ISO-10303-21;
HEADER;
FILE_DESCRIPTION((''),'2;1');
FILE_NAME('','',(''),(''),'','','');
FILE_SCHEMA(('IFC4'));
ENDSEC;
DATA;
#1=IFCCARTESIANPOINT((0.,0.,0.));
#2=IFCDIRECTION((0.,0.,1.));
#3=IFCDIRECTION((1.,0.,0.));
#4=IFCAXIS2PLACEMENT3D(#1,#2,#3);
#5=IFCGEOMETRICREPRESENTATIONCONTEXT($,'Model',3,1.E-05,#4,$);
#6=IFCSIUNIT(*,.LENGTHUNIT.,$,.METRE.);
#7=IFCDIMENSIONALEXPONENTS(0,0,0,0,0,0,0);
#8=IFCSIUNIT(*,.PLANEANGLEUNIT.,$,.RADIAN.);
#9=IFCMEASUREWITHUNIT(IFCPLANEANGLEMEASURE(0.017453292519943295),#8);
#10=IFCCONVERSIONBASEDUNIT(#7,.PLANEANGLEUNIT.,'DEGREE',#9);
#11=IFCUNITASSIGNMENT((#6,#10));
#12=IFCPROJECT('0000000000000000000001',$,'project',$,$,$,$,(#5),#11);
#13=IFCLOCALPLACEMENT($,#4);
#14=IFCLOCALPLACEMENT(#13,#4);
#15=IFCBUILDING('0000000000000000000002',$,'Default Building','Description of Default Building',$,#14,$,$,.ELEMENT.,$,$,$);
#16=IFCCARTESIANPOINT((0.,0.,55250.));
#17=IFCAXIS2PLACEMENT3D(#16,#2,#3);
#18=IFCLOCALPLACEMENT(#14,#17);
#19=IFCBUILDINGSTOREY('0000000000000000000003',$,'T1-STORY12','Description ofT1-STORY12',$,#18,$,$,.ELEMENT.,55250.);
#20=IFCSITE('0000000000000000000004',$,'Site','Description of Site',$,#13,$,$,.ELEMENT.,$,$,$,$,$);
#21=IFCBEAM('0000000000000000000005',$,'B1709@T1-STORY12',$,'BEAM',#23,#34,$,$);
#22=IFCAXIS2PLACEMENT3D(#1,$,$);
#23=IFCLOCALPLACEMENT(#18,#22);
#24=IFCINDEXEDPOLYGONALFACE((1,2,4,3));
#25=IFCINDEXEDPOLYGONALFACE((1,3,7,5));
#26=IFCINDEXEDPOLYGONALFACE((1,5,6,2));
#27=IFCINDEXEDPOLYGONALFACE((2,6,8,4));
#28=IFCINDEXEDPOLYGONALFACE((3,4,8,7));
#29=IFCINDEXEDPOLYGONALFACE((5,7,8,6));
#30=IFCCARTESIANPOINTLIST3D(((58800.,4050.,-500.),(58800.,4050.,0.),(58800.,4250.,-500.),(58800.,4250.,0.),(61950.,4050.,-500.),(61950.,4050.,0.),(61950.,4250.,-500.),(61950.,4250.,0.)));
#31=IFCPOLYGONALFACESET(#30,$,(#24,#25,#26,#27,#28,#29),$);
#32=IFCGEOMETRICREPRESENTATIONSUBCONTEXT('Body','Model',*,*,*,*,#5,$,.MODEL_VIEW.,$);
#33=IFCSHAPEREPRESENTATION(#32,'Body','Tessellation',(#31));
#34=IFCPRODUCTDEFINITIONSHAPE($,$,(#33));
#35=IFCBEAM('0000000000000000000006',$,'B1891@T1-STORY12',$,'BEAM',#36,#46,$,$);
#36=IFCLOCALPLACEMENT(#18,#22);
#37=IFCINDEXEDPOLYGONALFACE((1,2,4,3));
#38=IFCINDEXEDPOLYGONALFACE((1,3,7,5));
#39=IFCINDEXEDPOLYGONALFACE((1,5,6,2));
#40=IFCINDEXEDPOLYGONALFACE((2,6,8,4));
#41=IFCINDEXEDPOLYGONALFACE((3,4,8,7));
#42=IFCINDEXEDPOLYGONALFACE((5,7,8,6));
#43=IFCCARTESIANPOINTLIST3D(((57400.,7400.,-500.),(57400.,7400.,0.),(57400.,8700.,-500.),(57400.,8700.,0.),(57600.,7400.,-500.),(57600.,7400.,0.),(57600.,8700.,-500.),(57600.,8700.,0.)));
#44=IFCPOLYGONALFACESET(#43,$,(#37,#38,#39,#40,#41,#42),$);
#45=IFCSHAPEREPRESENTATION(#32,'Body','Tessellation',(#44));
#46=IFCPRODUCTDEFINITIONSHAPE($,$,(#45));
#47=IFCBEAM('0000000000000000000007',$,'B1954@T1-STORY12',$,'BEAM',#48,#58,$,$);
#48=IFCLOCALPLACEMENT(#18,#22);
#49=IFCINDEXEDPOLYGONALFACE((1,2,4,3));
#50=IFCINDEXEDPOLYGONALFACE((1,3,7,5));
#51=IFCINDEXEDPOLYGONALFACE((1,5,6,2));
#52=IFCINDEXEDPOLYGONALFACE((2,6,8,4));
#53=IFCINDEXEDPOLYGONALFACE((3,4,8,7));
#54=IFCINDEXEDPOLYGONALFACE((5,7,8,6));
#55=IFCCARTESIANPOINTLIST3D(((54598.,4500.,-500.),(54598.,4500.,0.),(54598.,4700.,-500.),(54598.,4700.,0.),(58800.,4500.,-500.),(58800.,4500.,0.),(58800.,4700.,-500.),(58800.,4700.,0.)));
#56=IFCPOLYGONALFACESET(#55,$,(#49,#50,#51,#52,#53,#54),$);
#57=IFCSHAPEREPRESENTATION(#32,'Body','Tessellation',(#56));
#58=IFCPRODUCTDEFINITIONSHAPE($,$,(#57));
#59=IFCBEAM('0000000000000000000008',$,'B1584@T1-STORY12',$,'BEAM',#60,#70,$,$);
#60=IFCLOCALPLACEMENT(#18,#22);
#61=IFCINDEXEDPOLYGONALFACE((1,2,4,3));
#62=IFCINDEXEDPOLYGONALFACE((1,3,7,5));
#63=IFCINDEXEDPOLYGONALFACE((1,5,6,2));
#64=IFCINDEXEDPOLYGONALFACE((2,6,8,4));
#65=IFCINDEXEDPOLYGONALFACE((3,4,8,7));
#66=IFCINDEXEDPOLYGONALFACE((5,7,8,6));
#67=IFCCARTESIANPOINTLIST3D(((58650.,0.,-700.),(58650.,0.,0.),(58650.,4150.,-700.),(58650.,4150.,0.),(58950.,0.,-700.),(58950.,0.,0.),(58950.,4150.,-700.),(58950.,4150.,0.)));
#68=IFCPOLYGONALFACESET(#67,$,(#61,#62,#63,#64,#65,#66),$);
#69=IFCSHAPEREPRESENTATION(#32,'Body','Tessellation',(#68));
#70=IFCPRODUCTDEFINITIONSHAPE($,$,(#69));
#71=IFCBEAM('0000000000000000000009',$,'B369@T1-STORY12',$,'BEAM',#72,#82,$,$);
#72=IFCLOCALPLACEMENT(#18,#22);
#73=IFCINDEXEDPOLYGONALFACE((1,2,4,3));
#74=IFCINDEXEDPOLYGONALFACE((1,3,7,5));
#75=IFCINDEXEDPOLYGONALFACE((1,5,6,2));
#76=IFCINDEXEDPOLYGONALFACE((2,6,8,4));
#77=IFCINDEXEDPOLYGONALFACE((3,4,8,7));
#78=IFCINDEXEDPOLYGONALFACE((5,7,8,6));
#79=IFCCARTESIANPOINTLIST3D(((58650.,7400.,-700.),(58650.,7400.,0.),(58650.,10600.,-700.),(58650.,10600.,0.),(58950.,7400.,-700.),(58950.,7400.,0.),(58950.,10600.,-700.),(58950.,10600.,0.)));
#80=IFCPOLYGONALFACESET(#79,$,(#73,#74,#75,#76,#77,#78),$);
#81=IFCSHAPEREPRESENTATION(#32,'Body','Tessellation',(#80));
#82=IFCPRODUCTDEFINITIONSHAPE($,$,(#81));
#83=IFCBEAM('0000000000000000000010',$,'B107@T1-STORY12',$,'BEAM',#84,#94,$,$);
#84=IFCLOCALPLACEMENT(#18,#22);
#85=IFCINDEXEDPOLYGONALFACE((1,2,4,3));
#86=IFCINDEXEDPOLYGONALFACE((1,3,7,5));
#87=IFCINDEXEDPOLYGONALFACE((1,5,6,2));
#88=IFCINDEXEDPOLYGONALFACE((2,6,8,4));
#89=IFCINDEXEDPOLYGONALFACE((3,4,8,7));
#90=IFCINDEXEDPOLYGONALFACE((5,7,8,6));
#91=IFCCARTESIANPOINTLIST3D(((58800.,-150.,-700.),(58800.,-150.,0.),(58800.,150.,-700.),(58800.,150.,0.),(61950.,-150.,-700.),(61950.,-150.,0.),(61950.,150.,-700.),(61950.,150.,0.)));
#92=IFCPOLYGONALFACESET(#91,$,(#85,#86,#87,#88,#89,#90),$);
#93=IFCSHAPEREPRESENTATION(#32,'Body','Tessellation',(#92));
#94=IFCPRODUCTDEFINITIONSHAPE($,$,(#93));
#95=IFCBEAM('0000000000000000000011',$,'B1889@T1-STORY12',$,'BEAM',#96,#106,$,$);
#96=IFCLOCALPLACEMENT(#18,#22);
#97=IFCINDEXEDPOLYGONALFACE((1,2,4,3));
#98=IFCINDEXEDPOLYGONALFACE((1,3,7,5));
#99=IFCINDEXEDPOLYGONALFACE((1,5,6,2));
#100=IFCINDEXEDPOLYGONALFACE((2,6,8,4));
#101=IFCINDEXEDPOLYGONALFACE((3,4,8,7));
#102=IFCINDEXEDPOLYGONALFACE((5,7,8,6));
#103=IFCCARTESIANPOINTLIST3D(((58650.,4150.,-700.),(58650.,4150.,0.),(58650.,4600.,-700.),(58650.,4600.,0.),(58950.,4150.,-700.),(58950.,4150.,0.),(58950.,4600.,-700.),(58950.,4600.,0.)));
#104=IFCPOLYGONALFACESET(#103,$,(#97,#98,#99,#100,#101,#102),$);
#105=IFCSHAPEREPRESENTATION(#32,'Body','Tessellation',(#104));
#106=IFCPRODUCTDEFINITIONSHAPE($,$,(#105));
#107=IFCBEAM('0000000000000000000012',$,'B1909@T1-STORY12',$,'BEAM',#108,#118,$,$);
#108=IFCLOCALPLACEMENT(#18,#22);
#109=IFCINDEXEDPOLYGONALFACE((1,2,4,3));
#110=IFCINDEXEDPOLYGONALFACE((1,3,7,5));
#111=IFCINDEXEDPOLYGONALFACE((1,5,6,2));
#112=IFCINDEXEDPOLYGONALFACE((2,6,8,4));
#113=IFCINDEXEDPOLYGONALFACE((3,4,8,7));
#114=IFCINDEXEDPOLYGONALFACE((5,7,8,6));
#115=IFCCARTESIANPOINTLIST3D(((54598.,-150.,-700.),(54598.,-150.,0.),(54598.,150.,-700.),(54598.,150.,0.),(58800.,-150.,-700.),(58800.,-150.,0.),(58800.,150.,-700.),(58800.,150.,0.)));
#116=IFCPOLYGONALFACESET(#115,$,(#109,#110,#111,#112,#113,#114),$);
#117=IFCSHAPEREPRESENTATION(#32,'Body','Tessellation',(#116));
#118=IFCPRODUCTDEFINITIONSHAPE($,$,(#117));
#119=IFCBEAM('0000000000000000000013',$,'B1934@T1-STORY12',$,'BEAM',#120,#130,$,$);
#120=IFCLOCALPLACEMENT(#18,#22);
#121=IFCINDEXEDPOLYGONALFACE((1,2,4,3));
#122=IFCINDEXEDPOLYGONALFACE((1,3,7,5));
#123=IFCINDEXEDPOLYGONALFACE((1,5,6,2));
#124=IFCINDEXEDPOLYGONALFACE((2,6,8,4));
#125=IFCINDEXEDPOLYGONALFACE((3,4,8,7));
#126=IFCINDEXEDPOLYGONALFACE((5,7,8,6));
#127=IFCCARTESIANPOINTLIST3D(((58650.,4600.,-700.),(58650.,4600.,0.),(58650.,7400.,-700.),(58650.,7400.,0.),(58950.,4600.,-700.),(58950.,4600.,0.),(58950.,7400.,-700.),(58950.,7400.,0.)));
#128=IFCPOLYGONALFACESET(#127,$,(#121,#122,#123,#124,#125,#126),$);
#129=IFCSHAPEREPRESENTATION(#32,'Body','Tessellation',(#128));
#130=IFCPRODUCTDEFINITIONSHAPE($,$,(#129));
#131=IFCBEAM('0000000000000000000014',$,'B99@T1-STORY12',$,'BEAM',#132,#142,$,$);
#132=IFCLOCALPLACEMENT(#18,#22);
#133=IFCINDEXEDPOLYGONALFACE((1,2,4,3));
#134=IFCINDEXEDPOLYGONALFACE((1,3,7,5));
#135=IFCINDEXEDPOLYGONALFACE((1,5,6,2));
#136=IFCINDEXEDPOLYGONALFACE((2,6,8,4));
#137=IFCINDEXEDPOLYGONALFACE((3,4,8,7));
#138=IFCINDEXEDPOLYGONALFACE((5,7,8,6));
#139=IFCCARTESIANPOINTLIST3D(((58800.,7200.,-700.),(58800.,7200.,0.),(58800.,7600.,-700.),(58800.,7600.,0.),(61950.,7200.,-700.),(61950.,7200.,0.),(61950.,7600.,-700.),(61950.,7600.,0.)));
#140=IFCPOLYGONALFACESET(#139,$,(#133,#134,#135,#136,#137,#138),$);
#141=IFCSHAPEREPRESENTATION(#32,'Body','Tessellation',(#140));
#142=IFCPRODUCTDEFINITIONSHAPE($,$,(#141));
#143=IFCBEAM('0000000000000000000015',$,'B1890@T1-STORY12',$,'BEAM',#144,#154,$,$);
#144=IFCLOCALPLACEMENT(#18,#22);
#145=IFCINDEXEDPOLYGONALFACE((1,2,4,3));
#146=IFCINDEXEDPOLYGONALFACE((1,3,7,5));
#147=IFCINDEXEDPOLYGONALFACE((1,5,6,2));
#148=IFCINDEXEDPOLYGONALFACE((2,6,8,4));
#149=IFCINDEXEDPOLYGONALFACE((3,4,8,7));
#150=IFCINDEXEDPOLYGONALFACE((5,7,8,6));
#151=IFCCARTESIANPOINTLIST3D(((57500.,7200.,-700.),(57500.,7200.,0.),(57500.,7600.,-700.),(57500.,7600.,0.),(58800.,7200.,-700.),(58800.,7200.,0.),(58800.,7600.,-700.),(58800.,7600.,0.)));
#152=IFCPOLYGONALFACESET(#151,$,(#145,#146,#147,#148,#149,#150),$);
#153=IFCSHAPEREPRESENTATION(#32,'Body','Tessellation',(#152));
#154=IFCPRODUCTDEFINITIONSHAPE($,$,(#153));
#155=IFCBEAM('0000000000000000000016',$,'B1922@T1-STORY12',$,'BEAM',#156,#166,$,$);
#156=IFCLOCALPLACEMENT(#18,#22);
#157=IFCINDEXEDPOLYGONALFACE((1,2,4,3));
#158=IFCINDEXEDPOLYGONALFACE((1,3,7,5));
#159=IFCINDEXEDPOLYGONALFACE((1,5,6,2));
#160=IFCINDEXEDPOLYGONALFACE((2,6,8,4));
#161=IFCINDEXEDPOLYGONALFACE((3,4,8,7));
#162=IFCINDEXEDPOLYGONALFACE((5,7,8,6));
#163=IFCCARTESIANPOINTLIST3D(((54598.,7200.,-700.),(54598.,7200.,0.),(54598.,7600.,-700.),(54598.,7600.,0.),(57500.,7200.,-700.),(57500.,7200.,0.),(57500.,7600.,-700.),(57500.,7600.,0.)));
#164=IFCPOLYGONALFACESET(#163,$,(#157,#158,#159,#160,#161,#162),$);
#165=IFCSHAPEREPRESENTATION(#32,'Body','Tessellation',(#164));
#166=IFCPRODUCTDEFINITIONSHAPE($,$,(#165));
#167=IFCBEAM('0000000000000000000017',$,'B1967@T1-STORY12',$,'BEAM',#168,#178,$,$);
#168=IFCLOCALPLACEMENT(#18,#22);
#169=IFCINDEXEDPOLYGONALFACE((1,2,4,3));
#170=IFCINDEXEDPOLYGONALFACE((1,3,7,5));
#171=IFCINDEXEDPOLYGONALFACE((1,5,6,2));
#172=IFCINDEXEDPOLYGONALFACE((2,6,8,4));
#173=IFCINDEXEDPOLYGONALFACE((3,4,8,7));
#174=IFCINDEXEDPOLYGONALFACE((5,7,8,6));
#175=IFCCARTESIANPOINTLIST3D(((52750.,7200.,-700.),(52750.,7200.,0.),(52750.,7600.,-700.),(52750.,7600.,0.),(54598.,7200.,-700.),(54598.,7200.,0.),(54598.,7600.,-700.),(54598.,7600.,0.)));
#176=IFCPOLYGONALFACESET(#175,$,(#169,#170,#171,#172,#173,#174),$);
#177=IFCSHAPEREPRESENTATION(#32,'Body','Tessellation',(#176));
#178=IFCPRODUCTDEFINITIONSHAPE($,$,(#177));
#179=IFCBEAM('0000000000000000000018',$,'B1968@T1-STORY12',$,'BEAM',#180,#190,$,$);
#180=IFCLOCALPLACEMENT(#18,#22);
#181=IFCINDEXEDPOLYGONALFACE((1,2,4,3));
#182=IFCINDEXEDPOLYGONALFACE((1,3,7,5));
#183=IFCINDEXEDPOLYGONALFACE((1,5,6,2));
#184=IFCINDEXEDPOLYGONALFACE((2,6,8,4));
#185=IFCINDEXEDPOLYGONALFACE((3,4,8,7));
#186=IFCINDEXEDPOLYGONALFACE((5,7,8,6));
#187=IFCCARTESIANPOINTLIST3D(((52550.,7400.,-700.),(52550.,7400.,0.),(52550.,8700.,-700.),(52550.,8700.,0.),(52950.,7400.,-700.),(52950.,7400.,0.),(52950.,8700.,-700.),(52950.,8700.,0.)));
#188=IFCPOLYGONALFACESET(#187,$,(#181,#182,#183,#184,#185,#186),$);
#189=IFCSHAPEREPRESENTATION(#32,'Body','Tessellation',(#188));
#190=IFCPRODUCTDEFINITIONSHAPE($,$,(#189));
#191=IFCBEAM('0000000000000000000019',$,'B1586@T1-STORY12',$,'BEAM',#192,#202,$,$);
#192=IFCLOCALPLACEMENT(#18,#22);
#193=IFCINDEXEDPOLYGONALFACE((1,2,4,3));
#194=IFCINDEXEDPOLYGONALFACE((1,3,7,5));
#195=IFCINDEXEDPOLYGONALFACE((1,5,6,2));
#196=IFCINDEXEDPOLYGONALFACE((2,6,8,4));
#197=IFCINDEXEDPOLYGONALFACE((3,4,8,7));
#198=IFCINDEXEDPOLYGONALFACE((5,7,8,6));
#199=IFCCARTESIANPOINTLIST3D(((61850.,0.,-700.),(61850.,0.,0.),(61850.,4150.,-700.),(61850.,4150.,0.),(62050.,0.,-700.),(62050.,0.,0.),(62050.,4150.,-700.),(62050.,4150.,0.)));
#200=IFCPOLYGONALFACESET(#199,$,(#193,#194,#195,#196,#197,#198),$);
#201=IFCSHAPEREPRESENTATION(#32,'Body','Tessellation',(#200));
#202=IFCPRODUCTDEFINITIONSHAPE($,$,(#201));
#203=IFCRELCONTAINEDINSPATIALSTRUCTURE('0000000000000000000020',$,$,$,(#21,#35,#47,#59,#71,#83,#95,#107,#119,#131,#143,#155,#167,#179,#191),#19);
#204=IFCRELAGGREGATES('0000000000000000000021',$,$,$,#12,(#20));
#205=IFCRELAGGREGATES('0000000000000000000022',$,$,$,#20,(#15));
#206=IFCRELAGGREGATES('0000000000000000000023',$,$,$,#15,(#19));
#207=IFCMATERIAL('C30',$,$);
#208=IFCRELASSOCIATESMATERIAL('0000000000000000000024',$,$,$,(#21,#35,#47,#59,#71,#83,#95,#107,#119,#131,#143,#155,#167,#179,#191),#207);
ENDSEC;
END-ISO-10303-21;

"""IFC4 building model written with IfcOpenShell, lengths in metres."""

from ifc_helpers import new_model, entity, si_unit, converted_unit, frame, origin_with_axes, place, context, subcontext, project, spatial, rectangle, extrude, material, element, save


model = new_model("IFC4")

# Units and contexts
model_context = context("Model", 3, precision=1e-05, world=origin_with_axes())
body_context = subcontext(model_context, "Body", "Model", "MODEL_VIEW")
ifc_project = project(units=[si_unit("LENGTHUNIT", "METRE"), converted_unit("PLANEANGLEUNIT", "DEGREE", entity("IfcPlaneAngleMeasure", 0.017453292519943295), si_unit("PLANEANGLEUNIT", "RADIAN"), dimensions=[0, 0, 0, 0, 0, 0, 0])], contexts=[model_context])

# Site, building, storey
site_placement = place(None, origin_with_axes())
site = spatial("IfcSite", under=ifc_project, at=site_placement, Name="Site", Description="Description of Site", CompositionType="ELEMENT")
building_placement = place(site_placement, origin_with_axes())
building = spatial("IfcBuilding", under=site, at=building_placement, Name="Default Building", Description="Description of Default Building", CompositionType="ELEMENT")
storey_placement = place(building_placement, frame((0.0, 0.0, 55250.0), z_axis=(0.0, 0.0, 1.0), x_axis=(1.0, 0.0, 0.0)))
storey = spatial("IfcBuildingStorey", under=building, at=storey_placement, Name="T1-STORY12", Description="Description ofT1-STORY12", CompositionType="ELEMENT", Elevation=55250.0)

# Beams
ifc_material_1 = material(Name="C30")
beam_1_placement = place(storey_placement, frame((58800.0, 4150.0, -250.0), z_axis=(1.0, 0.0, 0.0), x_axis=(0.0, 1.0, 0.0)))
element("IfcBeam", 1, at=beam_1_placement, inside=storey, material=ifc_material_1, Name="B1709@T1-STORY12", ObjectType="BEAM", context=body_context, shape_type="SweptSolid", body=[
    extrude(rectangle(XDim=200.0, YDim=500.0), origin_with_axes(), (0.0, 0.0, 1.0), 3150.0),
])
beam_2_placement = place(storey_placement, frame((57500.0, 7400.0, -250.0), z_axis=(0.0, 1.0, 0.0), x_axis=(-1.0, 0.0, 0.0)))
element("IfcBeam", 2, at=beam_2_placement, inside=storey, material=ifc_material_1, Name="B1891@T1-STORY12", ObjectType="BEAM", context=body_context, shape_type="SweptSolid", body=[
    extrude(rectangle(XDim=200.0, YDim=500.0), origin_with_axes(), (0.0, 0.0, 1.0), 1300.0),
])
beam_3_placement = place(storey_placement, frame((54598.0, 4600.0, -250.0), z_axis=(1.0, 0.0, 0.0), x_axis=(0.0, 1.0, 0.0)))
element("IfcBeam", 3, at=beam_3_placement, inside=storey, material=ifc_material_1, Name="B1954@T1-STORY12", ObjectType="BEAM", context=body_context, shape_type="SweptSolid", body=[
    extrude(rectangle(XDim=200.0, YDim=500.0), origin_with_axes(), (0.0, 0.0, 1.0), 4202.0),
])
beam_4_placement = place(storey_placement, frame((58800.0, 0.0, -350.0), z_axis=(0.0, 1.0, 0.0), x_axis=(-1.0, 0.0, 0.0)))
element("IfcBeam", 4, at=beam_4_placement, inside=storey, material=ifc_material_1, Name="B1584@T1-STORY12", ObjectType="BEAM", context=body_context, shape_type="SweptSolid", body=[
    extrude(rectangle(XDim=300.0, YDim=700.0), origin_with_axes(), (0.0, 0.0, 1.0), 4150.0),
])
beam_5_placement = place(storey_placement, frame((58800.0, 7400.0, -350.0), z_axis=(0.0, 1.0, 0.0), x_axis=(-1.0, 0.0, 0.0)))
element("IfcBeam", 5, at=beam_5_placement, inside=storey, material=ifc_material_1, Name="B369@T1-STORY12", ObjectType="BEAM", context=body_context, shape_type="SweptSolid", body=[
    extrude(rectangle(XDim=300.0, YDim=700.0), origin_with_axes(), (0.0, 0.0, 1.0), 3200.0),
])
beam_6_placement = place(storey_placement, frame((58800.0, 0.0, -350.0), z_axis=(1.0, 0.0, 0.0), x_axis=(0.0, 1.0, 0.0)))
element("IfcBeam", 6, at=beam_6_placement, inside=storey, material=ifc_material_1, Name="B107@T1-STORY12", ObjectType="BEAM", context=body_context, shape_type="SweptSolid", body=[
    extrude(rectangle(XDim=300.0, YDim=700.0), origin_with_axes(), (0.0, 0.0, 1.0), 3150.0),
])
beam_7_placement = place(storey_placement, frame((58800.0, 4150.0, -350.0), z_axis=(0.0, 1.0, 0.0), x_axis=(-1.0, 0.0, 0.0)))
element("IfcBeam", 7, at=beam_7_placement, inside=storey, material=ifc_material_1, Name="B1889@T1-STORY12", ObjectType="BEAM", context=body_context, shape_type="SweptSolid", body=[
    extrude(rectangle(XDim=300.0, YDim=700.0), origin_with_axes(), (0.0, 0.0, 1.0), 450.0),
])
beam_8_placement = place(storey_placement, frame((54598.0, 0.0, -350.0), z_axis=(1.0, 0.0, 0.0), x_axis=(0.0, 1.0, 0.0)))
element("IfcBeam", 8, at=beam_8_placement, inside=storey, material=ifc_material_1, Name="B1909@T1-STORY12", ObjectType="BEAM", context=body_context, shape_type="SweptSolid", body=[
    extrude(rectangle(XDim=300.0, YDim=700.0), origin_with_axes(), (0.0, 0.0, 1.0), 4202.0),
])
beam_9_placement = place(storey_placement, frame((58800.0, 4600.0, -350.0), z_axis=(0.0, 1.0, 0.0), x_axis=(-1.0, 0.0, 0.0)))
element("IfcBeam", 9, at=beam_9_placement, inside=storey, material=ifc_material_1, Name="B1934@T1-STORY12", ObjectType="BEAM", context=body_context, shape_type="SweptSolid", body=[
    extrude(rectangle(XDim=300.0, YDim=700.0), origin_with_axes(), (0.0, 0.0, 1.0), 2800.0),
])
beam_10_placement = place(storey_placement, frame((58800.0, 7400.0, -350.0), z_axis=(1.0, 0.0, 0.0), x_axis=(0.0, 1.0, 0.0)))
element("IfcBeam", 10, at=beam_10_placement, inside=storey, material=ifc_material_1, Name="B99@T1-STORY12", ObjectType="BEAM", context=body_context, shape_type="SweptSolid", body=[
    extrude(rectangle(XDim=400.0, YDim=700.0), origin_with_axes(), (0.0, 0.0, 1.0), 3150.0),
])
beam_11_placement = place(storey_placement, frame((57500.0, 7400.0, -350.0), z_axis=(1.0, 0.0, 0.0), x_axis=(0.0, 1.0, 0.0)))
element("IfcBeam", 11, at=beam_11_placement, inside=storey, material=ifc_material_1, Name="B1890@T1-STORY12", ObjectType="BEAM", context=body_context, shape_type="SweptSolid", body=[
    extrude(rectangle(XDim=400.0, YDim=700.0), origin_with_axes(), (0.0, 0.0, 1.0), 1300.0),
])
beam_12_placement = place(storey_placement, frame((54598.0, 7400.0, -350.0), z_axis=(1.0, 0.0, 0.0), x_axis=(0.0, 1.0, 0.0)))
element("IfcBeam", 12, at=beam_12_placement, inside=storey, material=ifc_material_1, Name="B1922@T1-STORY12", ObjectType="BEAM", context=body_context, shape_type="SweptSolid", body=[
    extrude(rectangle(XDim=400.0, YDim=700.0), origin_with_axes(), (0.0, 0.0, 1.0), 2902.0),
])
beam_13_placement = place(storey_placement, frame((52750.0, 7400.0, -350.0), z_axis=(1.0, 0.0, 0.0), x_axis=(0.0, 1.0, 0.0)))
element("IfcBeam", 13, at=beam_13_placement, inside=storey, material=ifc_material_1, Name="B1967@T1-STORY12", ObjectType="BEAM", context=body_context, shape_type="SweptSolid", body=[
    extrude(rectangle(XDim=400.0, YDim=700.0), origin_with_axes(), (0.0, 0.0, 1.0), 1848.0),
])
beam_14_placement = place(storey_placement, frame((52750.0, 7400.0, -350.0), z_axis=(0.0, 1.0, 0.0), x_axis=(-1.0, 0.0, 0.0)))
element("IfcBeam", 14, at=beam_14_placement, inside=storey, material=ifc_material_1, Name="B1968@T1-STORY12", ObjectType="BEAM", context=body_context, shape_type="SweptSolid", body=[
    extrude(rectangle(XDim=400.0, YDim=700.0), origin_with_axes(), (0.0, 0.0, 1.0), 1300.0),
])
beam_15_placement = place(storey_placement, frame((61950.0, 0.0, -350.0), z_axis=(0.0, 1.0, 0.0), x_axis=(-1.0, 0.0, 0.0)))
element("IfcBeam", 15, at=beam_15_placement, inside=storey, material=ifc_material_1, Name="B1586@T1-STORY12", ObjectType="BEAM", context=body_context, shape_type="SweptSolid", body=[
    extrude(rectangle(XDim=200.0, YDim=700.0), origin_with_axes(), (0.0, 0.0, 1.0), 4150.0),
])

save(model, "model.ifc")
